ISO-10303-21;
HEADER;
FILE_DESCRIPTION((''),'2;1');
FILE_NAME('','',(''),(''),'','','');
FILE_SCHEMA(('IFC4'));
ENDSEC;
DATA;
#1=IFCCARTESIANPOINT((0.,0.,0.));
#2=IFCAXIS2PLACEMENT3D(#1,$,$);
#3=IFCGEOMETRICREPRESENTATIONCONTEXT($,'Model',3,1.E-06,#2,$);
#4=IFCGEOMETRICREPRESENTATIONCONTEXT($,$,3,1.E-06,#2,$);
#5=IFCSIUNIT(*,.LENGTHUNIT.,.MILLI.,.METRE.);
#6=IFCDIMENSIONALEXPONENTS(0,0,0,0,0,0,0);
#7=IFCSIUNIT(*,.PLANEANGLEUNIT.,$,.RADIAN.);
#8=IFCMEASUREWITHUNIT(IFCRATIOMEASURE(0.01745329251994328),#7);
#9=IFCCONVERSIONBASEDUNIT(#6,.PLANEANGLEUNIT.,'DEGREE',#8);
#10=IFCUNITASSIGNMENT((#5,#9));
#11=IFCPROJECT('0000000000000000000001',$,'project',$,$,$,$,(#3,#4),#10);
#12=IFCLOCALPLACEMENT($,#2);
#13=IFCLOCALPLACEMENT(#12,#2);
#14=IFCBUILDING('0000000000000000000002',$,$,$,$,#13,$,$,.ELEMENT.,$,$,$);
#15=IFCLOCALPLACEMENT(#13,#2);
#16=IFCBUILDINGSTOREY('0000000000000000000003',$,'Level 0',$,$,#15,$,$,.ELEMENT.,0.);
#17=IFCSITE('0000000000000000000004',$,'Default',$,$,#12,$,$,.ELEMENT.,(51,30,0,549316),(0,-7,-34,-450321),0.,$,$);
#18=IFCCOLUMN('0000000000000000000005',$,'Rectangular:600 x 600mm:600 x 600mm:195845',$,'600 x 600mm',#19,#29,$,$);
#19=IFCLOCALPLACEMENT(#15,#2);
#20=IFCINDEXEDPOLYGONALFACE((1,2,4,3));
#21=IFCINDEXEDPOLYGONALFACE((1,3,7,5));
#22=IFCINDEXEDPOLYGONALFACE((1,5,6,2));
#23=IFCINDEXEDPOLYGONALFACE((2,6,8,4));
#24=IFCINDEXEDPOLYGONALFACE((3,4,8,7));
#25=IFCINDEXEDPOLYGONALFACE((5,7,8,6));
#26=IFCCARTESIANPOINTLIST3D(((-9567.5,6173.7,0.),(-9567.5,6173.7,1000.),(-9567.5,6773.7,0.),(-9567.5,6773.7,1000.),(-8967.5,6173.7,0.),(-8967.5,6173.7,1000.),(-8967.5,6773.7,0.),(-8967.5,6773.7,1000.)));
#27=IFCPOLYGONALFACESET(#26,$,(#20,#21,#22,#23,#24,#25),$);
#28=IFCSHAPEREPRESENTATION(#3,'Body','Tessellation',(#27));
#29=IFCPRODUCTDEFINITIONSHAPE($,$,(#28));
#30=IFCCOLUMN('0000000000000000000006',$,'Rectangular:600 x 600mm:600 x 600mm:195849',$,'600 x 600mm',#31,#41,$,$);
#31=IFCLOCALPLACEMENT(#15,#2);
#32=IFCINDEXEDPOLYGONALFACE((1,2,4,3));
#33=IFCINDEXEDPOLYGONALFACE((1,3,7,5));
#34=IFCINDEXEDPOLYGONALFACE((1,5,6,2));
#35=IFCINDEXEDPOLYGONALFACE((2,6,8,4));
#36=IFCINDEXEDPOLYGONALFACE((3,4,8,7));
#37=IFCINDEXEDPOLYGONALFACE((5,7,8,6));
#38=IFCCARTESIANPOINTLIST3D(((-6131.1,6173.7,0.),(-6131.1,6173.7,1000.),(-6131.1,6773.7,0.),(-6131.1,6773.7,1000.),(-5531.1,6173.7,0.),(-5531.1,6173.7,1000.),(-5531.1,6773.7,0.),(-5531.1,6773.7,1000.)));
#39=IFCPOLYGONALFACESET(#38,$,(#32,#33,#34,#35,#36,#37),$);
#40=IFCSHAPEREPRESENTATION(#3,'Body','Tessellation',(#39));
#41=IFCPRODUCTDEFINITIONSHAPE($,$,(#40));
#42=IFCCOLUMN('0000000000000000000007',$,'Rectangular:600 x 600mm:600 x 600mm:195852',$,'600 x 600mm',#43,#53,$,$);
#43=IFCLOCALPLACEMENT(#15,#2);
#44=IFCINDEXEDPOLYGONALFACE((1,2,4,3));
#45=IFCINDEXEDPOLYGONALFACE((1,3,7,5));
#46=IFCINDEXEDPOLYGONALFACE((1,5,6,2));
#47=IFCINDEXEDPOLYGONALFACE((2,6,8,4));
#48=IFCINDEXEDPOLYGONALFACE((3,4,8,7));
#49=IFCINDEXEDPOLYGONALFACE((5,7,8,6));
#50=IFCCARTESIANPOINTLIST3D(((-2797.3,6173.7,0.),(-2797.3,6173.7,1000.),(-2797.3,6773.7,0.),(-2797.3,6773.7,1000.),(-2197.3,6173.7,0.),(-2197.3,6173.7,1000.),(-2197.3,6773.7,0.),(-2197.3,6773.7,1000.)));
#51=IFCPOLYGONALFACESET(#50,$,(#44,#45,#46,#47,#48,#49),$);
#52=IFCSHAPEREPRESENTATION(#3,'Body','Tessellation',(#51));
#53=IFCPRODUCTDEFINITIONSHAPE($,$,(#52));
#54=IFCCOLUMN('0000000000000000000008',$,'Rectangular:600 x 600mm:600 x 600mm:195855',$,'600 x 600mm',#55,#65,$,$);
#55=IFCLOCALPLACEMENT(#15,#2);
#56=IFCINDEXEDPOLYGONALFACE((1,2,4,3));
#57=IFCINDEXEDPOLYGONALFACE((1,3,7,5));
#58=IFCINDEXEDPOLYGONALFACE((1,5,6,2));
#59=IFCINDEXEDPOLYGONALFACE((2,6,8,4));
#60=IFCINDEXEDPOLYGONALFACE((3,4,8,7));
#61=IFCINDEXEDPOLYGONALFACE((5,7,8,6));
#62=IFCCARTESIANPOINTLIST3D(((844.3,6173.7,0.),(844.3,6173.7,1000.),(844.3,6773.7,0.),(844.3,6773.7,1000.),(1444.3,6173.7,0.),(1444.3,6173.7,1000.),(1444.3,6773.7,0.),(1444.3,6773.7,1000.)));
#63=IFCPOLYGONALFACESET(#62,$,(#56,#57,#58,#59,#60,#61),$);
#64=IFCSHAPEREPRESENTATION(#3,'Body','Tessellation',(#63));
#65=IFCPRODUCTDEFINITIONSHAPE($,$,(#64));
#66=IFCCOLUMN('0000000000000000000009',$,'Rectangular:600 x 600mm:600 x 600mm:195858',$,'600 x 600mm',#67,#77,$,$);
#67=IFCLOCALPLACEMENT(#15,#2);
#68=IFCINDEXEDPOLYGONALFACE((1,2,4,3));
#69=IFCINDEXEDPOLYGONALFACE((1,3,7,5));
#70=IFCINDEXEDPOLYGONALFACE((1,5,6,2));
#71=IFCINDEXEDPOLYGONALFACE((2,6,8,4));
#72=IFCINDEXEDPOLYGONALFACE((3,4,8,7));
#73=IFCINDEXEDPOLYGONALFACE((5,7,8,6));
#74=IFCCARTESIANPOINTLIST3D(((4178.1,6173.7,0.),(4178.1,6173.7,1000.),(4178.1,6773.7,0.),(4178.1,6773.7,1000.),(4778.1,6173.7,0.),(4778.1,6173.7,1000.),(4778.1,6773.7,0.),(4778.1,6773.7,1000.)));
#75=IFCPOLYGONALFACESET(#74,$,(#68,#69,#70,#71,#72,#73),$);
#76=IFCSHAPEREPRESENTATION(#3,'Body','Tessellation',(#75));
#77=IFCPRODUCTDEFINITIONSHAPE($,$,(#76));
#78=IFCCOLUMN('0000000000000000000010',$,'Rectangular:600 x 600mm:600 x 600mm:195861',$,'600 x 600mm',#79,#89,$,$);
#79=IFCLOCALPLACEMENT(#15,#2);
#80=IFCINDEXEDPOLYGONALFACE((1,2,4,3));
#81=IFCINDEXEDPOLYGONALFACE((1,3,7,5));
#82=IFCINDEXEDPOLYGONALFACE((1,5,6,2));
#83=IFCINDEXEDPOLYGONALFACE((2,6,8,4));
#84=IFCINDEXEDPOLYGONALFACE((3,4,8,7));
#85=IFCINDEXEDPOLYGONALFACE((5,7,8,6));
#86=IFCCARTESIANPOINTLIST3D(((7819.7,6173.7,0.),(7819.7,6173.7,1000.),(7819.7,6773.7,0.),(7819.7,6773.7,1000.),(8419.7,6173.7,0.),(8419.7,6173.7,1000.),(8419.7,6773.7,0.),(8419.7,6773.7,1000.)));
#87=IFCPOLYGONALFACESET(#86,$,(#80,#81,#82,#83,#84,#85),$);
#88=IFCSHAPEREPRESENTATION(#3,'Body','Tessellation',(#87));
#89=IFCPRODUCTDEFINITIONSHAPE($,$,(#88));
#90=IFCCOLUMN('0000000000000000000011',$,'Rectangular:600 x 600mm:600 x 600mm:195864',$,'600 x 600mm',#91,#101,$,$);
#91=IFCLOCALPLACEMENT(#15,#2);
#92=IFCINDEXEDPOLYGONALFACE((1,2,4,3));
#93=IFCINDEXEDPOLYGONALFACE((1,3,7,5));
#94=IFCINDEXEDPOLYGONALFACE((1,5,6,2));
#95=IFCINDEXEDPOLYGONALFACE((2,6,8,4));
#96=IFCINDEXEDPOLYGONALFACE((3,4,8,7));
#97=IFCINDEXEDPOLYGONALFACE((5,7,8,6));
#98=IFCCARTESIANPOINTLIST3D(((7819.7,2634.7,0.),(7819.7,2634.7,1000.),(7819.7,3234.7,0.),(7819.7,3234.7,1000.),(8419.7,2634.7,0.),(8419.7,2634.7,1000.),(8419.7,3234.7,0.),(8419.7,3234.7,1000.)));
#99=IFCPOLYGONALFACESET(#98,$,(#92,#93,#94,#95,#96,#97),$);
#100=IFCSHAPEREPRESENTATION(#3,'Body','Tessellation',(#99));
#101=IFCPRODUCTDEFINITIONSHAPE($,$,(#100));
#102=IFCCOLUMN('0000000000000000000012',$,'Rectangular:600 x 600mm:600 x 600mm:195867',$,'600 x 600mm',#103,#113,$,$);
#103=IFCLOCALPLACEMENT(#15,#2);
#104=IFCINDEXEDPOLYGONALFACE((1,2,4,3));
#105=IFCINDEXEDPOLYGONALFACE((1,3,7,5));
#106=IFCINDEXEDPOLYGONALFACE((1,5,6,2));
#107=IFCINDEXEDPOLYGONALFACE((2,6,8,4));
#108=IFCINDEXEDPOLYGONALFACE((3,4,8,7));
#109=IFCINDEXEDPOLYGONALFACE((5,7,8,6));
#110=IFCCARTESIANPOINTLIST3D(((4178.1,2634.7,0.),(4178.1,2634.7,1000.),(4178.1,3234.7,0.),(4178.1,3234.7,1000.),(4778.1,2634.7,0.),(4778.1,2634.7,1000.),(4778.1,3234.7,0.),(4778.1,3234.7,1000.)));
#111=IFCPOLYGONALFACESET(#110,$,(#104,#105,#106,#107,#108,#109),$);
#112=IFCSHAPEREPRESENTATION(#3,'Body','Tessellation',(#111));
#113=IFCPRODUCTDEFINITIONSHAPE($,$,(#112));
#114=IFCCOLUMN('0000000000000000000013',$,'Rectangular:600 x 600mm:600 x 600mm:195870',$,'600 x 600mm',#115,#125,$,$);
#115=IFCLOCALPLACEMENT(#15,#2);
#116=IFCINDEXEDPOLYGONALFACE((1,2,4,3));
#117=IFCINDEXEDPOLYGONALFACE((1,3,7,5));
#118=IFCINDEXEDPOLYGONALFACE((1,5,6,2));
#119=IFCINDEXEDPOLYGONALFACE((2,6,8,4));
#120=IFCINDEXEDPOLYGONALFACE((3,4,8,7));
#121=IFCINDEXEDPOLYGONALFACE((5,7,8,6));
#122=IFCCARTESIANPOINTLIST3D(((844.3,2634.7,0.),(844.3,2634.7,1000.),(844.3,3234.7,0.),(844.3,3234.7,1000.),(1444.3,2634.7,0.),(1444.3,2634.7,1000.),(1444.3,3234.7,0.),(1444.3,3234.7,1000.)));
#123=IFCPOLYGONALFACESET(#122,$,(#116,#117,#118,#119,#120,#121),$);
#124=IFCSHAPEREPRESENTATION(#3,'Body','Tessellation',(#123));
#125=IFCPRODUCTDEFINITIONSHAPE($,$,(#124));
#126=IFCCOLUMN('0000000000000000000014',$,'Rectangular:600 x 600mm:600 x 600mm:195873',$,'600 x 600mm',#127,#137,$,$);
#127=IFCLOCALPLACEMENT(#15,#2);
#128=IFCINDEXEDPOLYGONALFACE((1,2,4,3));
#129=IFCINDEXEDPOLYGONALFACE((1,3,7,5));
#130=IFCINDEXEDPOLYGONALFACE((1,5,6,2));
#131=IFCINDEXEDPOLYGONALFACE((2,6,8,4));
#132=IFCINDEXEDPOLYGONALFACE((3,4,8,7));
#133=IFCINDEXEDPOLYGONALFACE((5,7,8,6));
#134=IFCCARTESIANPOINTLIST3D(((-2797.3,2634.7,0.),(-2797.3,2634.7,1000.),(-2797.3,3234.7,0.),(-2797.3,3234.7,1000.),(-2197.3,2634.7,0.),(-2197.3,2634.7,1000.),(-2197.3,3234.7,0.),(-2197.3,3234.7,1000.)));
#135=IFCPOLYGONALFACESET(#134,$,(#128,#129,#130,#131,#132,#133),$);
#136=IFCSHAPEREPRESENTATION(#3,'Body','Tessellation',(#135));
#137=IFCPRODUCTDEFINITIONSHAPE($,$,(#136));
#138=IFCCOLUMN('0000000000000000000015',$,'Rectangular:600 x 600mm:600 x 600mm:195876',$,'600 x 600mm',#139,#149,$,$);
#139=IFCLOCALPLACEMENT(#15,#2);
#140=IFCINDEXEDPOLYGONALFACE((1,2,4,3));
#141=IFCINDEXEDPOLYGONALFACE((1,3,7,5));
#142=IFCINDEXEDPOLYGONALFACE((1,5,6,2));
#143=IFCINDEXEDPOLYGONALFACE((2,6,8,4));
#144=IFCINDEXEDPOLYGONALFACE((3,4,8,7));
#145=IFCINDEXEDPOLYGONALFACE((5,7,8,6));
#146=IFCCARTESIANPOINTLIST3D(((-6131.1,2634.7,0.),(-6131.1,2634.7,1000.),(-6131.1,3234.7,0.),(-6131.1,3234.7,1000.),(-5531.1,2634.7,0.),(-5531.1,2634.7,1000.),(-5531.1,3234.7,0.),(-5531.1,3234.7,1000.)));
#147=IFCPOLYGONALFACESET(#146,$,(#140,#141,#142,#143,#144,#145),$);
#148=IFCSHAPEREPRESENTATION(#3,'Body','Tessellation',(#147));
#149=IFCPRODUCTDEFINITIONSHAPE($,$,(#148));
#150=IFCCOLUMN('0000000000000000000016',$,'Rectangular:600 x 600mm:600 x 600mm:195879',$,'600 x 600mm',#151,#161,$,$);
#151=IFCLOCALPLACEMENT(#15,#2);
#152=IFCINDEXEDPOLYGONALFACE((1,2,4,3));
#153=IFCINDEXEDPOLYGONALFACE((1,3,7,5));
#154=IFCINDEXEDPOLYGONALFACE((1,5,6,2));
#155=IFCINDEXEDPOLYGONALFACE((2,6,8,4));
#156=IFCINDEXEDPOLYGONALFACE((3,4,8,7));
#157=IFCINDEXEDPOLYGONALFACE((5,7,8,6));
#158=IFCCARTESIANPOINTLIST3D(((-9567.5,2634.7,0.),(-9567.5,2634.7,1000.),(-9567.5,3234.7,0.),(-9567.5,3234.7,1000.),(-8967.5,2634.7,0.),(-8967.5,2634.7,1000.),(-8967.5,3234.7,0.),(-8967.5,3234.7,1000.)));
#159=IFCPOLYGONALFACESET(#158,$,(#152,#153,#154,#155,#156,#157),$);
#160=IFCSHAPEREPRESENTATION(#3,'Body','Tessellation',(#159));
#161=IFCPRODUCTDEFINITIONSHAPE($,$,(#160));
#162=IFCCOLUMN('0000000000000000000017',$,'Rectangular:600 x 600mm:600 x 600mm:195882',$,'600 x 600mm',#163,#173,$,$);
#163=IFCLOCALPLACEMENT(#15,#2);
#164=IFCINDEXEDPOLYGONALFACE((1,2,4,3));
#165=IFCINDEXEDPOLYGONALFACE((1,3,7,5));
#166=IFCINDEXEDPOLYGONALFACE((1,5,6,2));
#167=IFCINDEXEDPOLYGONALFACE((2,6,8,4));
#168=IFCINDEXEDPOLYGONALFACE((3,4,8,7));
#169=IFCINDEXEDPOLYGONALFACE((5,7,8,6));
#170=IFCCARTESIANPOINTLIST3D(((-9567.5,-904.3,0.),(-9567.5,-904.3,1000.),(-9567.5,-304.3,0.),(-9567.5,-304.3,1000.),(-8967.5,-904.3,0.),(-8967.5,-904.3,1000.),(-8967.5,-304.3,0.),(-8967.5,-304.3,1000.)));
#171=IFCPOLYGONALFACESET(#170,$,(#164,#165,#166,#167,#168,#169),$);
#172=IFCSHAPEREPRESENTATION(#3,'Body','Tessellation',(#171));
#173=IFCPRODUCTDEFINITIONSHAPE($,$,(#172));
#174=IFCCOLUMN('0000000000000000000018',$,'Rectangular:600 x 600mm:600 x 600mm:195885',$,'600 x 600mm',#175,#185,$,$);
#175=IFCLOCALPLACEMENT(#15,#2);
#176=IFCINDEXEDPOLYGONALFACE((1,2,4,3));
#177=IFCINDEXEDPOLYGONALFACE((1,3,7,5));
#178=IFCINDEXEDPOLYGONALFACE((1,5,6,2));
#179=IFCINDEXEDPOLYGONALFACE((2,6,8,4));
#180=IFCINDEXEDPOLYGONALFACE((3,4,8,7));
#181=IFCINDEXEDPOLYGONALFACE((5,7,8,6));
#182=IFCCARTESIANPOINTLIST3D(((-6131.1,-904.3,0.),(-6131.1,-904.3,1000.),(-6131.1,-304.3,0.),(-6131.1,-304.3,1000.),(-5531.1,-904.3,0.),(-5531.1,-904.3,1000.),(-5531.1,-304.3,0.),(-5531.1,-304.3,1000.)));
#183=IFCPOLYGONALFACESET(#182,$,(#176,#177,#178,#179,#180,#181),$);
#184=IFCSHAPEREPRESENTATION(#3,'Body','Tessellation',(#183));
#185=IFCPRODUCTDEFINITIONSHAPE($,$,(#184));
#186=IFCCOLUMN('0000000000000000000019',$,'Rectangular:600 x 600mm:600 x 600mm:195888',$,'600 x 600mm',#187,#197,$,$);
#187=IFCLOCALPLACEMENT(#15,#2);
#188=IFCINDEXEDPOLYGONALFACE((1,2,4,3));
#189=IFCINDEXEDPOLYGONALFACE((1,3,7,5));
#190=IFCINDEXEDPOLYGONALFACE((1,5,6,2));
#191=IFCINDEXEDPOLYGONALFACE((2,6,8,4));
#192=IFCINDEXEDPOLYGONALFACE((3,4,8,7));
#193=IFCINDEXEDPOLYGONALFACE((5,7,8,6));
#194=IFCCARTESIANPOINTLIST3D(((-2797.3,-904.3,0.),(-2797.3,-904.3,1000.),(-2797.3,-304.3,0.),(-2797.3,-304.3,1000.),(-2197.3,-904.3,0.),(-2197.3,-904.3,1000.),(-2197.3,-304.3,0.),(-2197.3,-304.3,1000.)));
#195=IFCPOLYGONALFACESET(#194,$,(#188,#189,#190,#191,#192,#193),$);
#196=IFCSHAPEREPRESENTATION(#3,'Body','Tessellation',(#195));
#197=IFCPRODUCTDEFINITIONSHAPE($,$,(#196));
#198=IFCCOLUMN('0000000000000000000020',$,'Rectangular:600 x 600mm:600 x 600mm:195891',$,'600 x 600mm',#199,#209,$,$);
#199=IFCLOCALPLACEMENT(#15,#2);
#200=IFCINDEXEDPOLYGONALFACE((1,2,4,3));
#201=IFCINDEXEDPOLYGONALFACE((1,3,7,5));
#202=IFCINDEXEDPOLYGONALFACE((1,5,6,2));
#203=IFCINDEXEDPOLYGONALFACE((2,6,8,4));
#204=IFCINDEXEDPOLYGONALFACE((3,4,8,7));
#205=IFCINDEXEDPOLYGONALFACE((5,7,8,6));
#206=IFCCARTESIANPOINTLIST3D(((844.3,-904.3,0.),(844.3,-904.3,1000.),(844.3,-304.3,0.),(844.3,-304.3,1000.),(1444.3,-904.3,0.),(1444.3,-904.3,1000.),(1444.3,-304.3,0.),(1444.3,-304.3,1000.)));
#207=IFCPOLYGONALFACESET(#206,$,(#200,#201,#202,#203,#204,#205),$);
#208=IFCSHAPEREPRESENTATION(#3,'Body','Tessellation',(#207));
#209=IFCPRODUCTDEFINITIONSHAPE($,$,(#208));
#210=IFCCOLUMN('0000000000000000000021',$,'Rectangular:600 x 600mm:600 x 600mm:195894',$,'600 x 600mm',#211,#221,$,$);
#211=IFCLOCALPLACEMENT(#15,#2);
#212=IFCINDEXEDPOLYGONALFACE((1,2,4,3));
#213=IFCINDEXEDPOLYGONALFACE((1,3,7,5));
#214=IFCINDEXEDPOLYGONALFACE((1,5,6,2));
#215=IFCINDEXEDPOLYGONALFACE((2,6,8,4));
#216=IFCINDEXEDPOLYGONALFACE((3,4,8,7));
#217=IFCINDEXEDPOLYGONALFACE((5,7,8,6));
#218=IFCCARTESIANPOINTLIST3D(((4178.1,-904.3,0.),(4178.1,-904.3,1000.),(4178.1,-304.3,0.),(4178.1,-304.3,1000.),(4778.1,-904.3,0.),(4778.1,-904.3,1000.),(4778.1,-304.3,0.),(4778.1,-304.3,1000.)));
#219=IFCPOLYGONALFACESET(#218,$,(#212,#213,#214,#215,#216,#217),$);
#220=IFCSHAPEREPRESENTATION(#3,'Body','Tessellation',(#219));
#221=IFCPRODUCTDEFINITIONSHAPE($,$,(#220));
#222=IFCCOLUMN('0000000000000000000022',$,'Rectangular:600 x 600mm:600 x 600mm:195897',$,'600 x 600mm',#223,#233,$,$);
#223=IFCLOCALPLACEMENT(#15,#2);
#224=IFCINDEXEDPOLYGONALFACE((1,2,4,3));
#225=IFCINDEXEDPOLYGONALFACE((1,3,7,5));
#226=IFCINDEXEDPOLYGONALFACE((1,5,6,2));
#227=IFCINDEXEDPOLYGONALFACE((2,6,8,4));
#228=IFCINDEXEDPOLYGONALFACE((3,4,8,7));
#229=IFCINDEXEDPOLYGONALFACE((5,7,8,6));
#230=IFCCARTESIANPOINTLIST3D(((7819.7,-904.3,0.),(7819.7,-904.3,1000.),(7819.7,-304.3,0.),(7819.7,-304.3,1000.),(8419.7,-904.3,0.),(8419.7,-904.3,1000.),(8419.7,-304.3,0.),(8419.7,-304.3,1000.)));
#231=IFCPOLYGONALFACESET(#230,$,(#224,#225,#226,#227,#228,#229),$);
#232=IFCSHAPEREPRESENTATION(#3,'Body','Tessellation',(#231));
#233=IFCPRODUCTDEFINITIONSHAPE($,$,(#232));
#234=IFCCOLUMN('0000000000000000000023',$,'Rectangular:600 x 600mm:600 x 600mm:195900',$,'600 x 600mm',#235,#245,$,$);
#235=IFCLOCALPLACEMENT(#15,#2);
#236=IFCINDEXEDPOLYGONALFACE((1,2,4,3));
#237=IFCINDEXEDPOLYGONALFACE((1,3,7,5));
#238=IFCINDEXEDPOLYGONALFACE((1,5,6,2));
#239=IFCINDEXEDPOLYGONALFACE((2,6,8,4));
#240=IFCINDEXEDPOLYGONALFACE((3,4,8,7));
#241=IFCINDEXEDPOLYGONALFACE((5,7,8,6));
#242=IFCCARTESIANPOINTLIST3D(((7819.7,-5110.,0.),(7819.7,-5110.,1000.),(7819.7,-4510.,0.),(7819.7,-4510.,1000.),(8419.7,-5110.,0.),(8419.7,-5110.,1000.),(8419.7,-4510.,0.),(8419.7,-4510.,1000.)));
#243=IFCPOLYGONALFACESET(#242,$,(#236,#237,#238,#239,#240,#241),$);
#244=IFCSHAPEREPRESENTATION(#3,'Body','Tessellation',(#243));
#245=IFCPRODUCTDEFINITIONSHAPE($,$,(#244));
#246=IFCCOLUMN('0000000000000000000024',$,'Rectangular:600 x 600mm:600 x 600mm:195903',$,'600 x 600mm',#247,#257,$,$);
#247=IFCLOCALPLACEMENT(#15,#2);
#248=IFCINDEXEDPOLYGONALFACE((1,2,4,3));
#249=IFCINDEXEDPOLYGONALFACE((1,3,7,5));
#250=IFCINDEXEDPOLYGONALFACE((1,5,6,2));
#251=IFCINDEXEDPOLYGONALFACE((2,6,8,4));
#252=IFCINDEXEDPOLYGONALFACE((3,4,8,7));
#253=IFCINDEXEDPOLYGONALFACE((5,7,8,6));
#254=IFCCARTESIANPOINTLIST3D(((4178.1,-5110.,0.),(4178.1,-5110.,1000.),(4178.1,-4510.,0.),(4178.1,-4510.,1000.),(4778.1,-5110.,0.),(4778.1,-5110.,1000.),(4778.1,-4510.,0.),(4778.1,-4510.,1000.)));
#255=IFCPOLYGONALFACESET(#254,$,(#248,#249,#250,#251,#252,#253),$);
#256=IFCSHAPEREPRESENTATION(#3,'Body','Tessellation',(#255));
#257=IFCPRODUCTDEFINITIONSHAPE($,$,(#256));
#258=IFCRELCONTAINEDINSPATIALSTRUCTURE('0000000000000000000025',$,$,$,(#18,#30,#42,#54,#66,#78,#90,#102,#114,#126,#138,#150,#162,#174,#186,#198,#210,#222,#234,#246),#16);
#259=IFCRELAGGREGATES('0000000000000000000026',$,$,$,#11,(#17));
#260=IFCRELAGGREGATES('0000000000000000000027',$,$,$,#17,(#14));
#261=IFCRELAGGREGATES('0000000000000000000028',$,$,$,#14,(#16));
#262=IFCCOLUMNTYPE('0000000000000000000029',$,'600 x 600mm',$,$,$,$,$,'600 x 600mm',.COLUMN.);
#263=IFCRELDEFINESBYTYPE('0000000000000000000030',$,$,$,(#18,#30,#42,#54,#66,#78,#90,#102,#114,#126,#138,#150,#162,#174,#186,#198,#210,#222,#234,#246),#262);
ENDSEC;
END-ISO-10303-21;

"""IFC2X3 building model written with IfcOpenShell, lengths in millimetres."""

from ifc_helpers import new_model, entity, si_unit, converted_unit, frame, frame_2d, origin, place, context, project, spatial, rectangle, extrude, source, transform, mapped, type_object, type_shapes, element, save


model = new_model("IFC2X3")

# Units and contexts
model_context = context("Model", 3, precision=1e-06, world=origin())
context_of_model = context(None, 3, precision=1e-06, world=origin())
ifc_project = project(units=[si_unit("LENGTHUNIT", "METRE", prefix="MILLI"), converted_unit("PLANEANGLEUNIT", "DEGREE", entity("IfcRatioMeasure", 0.01745329251994328), si_unit("PLANEANGLEUNIT", "RADIAN"), dimensions=[0, 0, 0, 0, 0, 0, 0])], contexts=[model_context, context_of_model])

# Site, building, storey
site_placement = place(None, origin())
site = spatial("IfcSite", under=ifc_project, at=site_placement, Name="Default", CompositionType="ELEMENT", RefLatitude=(51, 30, 0, 549316), RefLongitude=(0, -7, -34, -450321), RefElevation=0.0)
building_placement = place(site_placement, origin())
building = spatial("IfcBuilding", under=site, at=building_placement, CompositionType="ELEMENT")
storey_placement = place(building_placement, origin())
storey = spatial("IfcBuildingStorey", under=building, at=storey_placement, Name="Level 0", CompositionType="ELEMENT", Elevation=0.0)

# Columns
column_type = type_object("IfcColumnType", Name="600 x 600mm", ElementType="600 x 600mm", PredefinedType="COLUMN")
shared_shape = source(origin(), model_context, "Body", "SweptSolid", [
    extrude(rectangle(XDim=600.0, YDim=600.0, at=frame_2d((0.0, 0.0), x_axis=(0.0, -1.0))), origin(), (0.0, 0.0, 1.0), 1000.0),
])
type_shapes(column_type, [shared_shape])
for number, where, name in (
    (1, (-9267.5, 6473.7, 0.0), "Rectangular:600 x 600mm:600 x 600mm:195845"),
    (2, (-5831.1, 6473.7, 0.0), "Rectangular:600 x 600mm:600 x 600mm:195849"),
    (3, (-2497.3, 6473.7, 0.0), "Rectangular:600 x 600mm:600 x 600mm:195852"),
    (4, (1144.3, 6473.7, 0.0), "Rectangular:600 x 600mm:600 x 600mm:195855"),
    (5, (4478.1, 6473.7, 0.0), "Rectangular:600 x 600mm:600 x 600mm:195858"),
    (6, (8119.7, 6473.7, 0.0), "Rectangular:600 x 600mm:600 x 600mm:195861"),
    (7, (8119.7, 2934.7, 0.0), "Rectangular:600 x 600mm:600 x 600mm:195864"),
    (8, (4478.1, 2934.7, 0.0), "Rectangular:600 x 600mm:600 x 600mm:195867"),
    (9, (1144.3, 2934.7, 0.0), "Rectangular:600 x 600mm:600 x 600mm:195870"),
    (10, (-2497.3, 2934.7, 0.0), "Rectangular:600 x 600mm:600 x 600mm:195873"),
    (11, (-5831.1, 2934.7, 0.0), "Rectangular:600 x 600mm:600 x 600mm:195876"),
    (12, (-9267.5, 2934.7, 0.0), "Rectangular:600 x 600mm:600 x 600mm:195879"),
    (13, (-9267.5, -604.3, 0.0), "Rectangular:600 x 600mm:600 x 600mm:195882"),
    (14, (-5831.1, -604.3, 0.0), "Rectangular:600 x 600mm:600 x 600mm:195885"),
    (15, (-2497.3, -604.3, 0.0), "Rectangular:600 x 600mm:600 x 600mm:195888"),
    (16, (1144.3, -604.3, 0.0), "Rectangular:600 x 600mm:600 x 600mm:195891"),
    (17, (4478.1, -604.3, 0.0), "Rectangular:600 x 600mm:600 x 600mm:195894"),
    (18, (8119.7, -604.3, 0.0), "Rectangular:600 x 600mm:600 x 600mm:195897"),
    (19, (8119.7, -4810.0, 0.0), "Rectangular:600 x 600mm:600 x 600mm:195900"),
    (20, (4478.1, -4810.0, 0.0), "Rectangular:600 x 600mm:600 x 600mm:195903"),
):
    element("IfcColumn", number, at=place(storey_placement, frame(where)), inside=storey, type_object=column_type, Name=name, ObjectType="600 x 600mm", context=model_context, shape_type="MappedRepresentation", body=[
        mapped(shared_shape, transform((0.0, 0.0, 0.0), scale=1.0)),
    ])

save(model, "model.ifc")
